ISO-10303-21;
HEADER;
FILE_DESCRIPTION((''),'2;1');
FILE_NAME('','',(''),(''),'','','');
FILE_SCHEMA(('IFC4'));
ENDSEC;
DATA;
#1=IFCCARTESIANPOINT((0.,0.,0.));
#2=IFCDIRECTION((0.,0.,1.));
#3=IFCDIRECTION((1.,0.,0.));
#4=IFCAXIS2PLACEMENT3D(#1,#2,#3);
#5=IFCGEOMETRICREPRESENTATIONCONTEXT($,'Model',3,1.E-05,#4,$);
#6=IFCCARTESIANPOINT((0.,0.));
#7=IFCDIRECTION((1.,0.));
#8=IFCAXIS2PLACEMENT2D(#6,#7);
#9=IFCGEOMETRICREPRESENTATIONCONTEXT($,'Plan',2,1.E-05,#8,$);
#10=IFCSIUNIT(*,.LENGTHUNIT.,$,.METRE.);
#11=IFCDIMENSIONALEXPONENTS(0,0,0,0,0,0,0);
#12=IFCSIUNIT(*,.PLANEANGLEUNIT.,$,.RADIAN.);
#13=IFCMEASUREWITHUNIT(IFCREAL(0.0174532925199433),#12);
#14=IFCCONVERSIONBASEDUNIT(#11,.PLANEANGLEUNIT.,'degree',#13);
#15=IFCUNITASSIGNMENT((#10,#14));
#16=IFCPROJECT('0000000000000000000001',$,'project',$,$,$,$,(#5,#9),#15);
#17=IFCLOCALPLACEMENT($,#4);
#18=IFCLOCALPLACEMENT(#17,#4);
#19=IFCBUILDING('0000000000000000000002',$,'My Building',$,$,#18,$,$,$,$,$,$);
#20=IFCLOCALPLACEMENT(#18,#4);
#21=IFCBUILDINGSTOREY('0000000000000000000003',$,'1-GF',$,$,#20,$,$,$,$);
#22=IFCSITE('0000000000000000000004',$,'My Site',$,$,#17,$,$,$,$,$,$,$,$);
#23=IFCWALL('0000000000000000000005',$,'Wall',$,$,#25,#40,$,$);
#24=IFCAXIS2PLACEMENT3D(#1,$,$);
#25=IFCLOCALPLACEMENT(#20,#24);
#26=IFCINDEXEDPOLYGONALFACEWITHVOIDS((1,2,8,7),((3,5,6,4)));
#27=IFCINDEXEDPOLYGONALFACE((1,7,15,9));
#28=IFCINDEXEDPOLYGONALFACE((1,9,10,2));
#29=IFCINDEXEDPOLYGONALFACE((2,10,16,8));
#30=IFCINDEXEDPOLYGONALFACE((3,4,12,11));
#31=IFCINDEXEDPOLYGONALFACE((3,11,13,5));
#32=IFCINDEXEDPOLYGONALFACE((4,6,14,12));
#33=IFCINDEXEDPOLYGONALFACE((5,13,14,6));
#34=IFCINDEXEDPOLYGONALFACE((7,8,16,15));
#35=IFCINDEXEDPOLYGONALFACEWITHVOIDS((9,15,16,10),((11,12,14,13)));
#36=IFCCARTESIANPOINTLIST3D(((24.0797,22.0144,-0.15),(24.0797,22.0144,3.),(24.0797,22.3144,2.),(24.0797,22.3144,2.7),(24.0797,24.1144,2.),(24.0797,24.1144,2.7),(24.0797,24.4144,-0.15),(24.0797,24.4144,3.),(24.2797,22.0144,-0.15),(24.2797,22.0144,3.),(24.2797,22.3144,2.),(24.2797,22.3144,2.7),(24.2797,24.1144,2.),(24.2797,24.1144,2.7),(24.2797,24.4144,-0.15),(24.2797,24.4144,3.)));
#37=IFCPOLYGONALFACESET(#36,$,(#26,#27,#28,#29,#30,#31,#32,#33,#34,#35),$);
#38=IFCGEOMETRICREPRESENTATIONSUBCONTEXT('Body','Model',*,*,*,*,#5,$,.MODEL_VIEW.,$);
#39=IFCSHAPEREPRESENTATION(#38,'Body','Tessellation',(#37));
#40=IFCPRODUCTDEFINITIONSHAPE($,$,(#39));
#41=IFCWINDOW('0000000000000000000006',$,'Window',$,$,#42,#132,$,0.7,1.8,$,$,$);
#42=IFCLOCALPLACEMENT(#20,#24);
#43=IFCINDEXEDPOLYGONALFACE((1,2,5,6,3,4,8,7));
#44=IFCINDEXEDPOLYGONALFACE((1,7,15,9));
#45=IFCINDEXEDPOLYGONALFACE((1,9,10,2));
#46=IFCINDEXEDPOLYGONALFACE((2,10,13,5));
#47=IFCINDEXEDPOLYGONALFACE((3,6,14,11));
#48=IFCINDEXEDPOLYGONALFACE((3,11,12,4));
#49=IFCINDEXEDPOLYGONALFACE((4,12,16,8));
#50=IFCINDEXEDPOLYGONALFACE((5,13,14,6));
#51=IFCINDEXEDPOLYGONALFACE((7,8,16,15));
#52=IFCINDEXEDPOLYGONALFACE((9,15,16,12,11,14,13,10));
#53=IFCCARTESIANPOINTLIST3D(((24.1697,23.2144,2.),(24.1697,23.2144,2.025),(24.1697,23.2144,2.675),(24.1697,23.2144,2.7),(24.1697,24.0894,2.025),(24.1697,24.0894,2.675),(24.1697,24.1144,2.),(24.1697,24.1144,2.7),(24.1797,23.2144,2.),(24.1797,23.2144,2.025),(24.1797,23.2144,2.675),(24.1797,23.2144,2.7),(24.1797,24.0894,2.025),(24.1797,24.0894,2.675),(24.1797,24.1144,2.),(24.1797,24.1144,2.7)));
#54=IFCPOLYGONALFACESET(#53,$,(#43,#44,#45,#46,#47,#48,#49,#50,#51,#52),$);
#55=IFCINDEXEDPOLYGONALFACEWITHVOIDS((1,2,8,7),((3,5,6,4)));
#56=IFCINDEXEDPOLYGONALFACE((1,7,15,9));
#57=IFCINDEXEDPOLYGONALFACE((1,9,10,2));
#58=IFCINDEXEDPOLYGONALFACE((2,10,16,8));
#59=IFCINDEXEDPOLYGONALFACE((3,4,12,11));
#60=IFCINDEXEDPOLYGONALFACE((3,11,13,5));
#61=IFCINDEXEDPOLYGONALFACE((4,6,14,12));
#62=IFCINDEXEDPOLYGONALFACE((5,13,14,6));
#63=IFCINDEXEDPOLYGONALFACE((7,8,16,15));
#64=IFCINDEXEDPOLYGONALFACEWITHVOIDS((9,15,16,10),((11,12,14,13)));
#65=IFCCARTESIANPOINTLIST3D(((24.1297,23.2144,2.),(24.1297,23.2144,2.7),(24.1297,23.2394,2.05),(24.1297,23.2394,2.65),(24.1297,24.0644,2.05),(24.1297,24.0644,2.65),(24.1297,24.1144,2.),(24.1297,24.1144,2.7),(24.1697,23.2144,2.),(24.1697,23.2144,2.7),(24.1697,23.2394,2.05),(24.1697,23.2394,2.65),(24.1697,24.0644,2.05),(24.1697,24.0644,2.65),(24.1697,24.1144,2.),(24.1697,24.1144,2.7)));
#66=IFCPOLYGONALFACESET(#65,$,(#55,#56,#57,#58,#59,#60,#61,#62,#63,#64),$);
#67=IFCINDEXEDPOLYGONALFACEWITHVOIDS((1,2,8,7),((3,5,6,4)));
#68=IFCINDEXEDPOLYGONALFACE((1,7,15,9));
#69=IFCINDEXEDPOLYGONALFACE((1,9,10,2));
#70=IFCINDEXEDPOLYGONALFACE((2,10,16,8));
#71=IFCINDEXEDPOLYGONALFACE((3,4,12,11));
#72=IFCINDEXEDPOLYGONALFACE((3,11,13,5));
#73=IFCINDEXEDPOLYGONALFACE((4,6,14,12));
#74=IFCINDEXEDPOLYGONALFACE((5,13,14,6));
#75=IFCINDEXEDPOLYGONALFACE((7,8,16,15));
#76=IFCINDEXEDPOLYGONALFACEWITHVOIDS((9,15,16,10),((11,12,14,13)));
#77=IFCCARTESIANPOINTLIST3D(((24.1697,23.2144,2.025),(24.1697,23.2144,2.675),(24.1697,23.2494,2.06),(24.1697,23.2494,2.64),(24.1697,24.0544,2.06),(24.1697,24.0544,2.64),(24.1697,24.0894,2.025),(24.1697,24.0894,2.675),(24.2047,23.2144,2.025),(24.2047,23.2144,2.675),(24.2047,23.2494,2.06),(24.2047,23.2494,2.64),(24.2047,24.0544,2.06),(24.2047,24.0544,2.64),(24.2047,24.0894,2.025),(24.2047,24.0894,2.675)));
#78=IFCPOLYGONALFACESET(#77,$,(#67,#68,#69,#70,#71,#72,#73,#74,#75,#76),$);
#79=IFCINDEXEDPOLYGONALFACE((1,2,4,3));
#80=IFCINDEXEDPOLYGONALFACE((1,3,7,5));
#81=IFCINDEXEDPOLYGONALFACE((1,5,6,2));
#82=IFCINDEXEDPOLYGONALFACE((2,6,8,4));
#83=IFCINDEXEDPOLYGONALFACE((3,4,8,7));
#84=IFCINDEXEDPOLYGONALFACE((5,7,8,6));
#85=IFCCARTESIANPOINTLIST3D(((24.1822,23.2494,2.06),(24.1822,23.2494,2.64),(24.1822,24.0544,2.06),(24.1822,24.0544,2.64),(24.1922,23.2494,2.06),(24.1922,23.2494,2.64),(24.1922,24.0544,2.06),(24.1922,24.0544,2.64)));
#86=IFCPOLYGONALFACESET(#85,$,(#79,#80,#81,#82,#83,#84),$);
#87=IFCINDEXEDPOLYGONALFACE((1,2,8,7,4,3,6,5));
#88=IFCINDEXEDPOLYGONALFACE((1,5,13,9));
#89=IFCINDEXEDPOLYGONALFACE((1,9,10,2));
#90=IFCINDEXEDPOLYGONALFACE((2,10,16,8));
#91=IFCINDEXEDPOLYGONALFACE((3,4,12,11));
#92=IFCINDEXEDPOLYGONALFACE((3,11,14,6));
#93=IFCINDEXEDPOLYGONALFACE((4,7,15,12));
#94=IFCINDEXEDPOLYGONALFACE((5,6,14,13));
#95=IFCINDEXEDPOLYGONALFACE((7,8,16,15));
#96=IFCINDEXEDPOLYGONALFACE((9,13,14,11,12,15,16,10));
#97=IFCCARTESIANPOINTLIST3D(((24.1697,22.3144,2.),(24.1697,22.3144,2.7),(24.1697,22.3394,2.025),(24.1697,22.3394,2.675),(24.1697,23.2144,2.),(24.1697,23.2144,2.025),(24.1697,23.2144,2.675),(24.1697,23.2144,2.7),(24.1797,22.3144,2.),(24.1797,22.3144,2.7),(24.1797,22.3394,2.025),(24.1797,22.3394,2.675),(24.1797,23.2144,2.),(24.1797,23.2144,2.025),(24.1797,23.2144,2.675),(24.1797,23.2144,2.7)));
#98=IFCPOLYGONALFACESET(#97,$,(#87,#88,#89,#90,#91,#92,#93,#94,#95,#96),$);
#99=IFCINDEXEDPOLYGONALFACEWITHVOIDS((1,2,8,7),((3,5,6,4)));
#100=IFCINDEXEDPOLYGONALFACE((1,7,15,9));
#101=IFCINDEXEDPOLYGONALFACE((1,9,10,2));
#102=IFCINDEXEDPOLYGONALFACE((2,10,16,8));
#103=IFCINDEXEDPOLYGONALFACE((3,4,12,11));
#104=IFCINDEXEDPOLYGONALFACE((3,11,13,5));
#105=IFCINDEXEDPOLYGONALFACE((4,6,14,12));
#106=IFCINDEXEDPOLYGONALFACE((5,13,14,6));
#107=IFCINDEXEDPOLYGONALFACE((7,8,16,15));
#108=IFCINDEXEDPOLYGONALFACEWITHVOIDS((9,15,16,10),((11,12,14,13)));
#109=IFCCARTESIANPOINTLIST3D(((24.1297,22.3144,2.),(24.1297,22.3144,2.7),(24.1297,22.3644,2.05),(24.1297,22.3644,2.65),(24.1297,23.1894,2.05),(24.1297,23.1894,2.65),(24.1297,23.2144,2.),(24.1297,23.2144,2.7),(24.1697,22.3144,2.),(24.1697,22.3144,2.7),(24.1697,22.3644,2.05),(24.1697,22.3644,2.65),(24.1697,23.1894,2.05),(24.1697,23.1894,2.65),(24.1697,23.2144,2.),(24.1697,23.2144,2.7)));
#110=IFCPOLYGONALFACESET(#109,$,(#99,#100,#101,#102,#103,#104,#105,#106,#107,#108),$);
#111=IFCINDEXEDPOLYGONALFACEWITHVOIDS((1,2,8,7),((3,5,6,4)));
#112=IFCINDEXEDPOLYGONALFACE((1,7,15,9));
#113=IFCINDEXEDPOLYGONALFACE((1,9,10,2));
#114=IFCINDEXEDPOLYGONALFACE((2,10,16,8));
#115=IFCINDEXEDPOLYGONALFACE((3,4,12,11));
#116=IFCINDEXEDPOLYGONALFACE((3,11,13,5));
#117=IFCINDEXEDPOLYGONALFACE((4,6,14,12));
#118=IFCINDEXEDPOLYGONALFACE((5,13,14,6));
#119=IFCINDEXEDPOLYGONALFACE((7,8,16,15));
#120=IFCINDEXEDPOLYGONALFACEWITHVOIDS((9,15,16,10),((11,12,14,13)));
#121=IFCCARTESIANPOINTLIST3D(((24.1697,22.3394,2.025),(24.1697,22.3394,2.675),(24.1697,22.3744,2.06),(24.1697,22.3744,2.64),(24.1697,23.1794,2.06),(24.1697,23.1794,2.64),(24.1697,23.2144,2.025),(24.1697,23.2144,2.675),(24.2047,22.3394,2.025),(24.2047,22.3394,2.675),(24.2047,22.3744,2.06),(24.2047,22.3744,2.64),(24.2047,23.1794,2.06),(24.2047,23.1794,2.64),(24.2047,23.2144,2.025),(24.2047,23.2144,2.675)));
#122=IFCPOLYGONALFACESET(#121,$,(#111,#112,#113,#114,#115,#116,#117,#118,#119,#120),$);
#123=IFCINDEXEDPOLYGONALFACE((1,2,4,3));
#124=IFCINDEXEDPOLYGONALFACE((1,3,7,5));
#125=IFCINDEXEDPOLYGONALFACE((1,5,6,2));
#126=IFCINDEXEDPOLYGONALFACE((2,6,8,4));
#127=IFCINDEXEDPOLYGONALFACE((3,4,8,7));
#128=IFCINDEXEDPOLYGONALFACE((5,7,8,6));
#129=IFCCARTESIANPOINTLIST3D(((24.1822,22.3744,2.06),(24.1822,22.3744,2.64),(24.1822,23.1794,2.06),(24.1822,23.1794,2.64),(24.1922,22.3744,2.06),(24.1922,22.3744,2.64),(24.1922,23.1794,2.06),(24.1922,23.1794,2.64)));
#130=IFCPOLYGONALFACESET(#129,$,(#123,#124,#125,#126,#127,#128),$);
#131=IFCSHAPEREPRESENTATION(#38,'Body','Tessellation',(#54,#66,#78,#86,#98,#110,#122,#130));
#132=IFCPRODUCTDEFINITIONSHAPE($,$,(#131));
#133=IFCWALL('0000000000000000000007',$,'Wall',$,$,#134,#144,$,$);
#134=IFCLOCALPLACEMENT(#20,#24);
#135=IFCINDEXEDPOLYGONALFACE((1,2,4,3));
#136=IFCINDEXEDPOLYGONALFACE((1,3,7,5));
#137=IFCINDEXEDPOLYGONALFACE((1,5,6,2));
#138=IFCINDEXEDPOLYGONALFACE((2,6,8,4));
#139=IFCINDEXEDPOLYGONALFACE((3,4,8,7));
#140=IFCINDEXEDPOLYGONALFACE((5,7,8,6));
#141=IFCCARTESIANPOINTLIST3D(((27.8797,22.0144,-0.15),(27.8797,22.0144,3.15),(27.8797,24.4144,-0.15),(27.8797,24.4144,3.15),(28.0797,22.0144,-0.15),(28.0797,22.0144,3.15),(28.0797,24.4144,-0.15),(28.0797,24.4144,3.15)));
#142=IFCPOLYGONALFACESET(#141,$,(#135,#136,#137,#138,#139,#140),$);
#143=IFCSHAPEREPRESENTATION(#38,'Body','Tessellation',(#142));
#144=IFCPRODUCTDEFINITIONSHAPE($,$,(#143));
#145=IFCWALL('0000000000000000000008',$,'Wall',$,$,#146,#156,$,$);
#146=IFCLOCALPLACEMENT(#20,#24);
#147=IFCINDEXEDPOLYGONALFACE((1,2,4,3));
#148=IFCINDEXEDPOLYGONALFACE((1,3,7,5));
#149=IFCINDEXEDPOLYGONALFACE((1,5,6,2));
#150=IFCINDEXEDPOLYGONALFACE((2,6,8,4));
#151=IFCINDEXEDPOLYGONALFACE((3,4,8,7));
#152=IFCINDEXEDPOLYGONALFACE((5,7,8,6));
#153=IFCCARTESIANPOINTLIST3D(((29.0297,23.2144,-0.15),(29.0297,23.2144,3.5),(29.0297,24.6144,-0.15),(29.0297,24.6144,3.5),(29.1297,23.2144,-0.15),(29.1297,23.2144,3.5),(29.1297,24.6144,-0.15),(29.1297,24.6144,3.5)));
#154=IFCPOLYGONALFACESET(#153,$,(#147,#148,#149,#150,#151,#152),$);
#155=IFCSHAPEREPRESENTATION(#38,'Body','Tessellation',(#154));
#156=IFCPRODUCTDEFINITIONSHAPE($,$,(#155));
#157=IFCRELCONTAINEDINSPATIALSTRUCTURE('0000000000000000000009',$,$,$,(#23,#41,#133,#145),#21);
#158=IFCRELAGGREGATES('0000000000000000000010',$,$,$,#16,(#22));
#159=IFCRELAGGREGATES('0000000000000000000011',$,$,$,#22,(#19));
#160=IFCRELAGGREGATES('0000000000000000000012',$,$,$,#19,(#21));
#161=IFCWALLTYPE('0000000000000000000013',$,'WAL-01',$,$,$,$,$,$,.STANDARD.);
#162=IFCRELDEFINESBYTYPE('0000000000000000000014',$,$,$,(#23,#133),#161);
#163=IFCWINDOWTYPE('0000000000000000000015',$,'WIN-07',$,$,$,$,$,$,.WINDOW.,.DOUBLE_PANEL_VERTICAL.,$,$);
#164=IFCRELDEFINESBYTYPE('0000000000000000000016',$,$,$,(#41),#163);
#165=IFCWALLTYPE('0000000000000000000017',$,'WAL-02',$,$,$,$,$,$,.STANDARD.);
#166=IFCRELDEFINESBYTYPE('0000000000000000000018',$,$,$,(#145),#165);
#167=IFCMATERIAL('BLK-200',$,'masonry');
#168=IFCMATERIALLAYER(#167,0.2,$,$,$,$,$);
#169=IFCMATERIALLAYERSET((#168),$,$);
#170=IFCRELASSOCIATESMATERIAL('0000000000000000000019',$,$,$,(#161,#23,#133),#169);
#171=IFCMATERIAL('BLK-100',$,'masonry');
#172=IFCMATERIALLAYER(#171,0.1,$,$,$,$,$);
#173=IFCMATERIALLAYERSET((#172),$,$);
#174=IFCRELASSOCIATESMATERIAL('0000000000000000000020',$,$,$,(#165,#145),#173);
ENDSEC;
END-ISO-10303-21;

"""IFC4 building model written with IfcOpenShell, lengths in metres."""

from ifc_helpers import new_model, entity, si_unit, converted_unit, frame, origin_with_axes, origin_2d_with_axis, place, context, subcontext, project, spatial, line, indexed_curve, outline, extrude, shape, source, transform, mapped, material, layer, layer_set, layer_usage, type_object, type_shapes, element, fill, save


model = new_model("IFC4")

# Units and contexts
model_context = context("Model", 3, precision=1e-05, world=origin_with_axes())
plan_context = context("Plan", 2, precision=1e-05, world=origin_2d_with_axis())
body_context_1 = subcontext(model_context, "Body", "Model", "MODEL_VIEW")
body_context_2 = subcontext(plan_context, "Body", "Plan", "PLAN_VIEW")
ifc_project = project(units=[si_unit("LENGTHUNIT", "METRE"), converted_unit("PLANEANGLEUNIT", "degree", entity("IfcReal", 0.0174532925199433), si_unit("PLANEANGLEUNIT", "RADIAN"), dimensions=[0, 0, 0, 0, 0, 0, 0])], contexts=[model_context, plan_context])

# Site, building, storey
site_placement = place(None, origin_with_axes())
site = spatial("IfcSite", under=ifc_project, at=site_placement, Name="My Site")
building_placement = place(site_placement, origin_with_axes())
building = spatial("IfcBuilding", under=site, at=building_placement, Name="My Building")
storey_placement = place(building_placement, origin_with_axes())
storey = spatial("IfcBuildingStorey", under=building, at=storey_placement, Name="1-GF")

# Wall, opening, window
ifc_material_1 = material(Name="BLK-200", Category="masonry")
ifc_layer_1 = layer(ifc_material_1, 0.2)
ifc_layer_set_1 = layer_set([ifc_layer_1])
ifc_layer_usage_1 = layer_usage(ifc_layer_set_1, "AXIS2", "POSITIVE", 0.0)
wall_type_1 = type_object("IfcWallType", Name="WAL-01", PredefinedType="STANDARD", material=ifc_layer_set_1)
wall_1_placement = place(storey_placement, frame((24.0797, 24.4144, -0.15), z_axis=(0.0, 0.0, 1.0), x_axis=(-0.000001, -1.0, 0.0)))
wall_1 = element("IfcWall", 1, at=wall_1_placement, inside=storey, type_object=wall_type_1, material=ifc_layer_usage_1, Name="Wall", context=body_context_1, shape_type="SweptSolid", body=[
    extrude(outline(indexed_curve([(0.0, 0.0), (0.0, 0.2), (2.4, 0.2), (2.4, 0.0), (0.0, 0.0)], self_intersect=False)), origin_with_axes(), (0.0, 0.0, 1.0), 3.15),
])
shared_shape_1 = source(origin_with_axes(), body_context_1, "Body", "SweptSolid", [
    extrude(outline(indexed_curve([(0.0, 0.0), (1.8, 0.0), (1.8, 0.7), (0.0, 0.7)], segments=[line(1, 2, 3, 4, 1)])), frame((0.0, -0.1, 0.0), z_axis=(0.0, -1.0, 0.0), x_axis=(1.0, 0.0, 0.0)), (0.0, 0.0, -1.0), 0.4),
])
opening_1_placement = place(wall_1_placement, frame((0.3, 0.0, 2.15), z_axis=(0.0, 0.0, 1.0), x_axis=(1.0, 0.0, 0.0)))
opening_1 = element("IfcOpeningElement", 2, at=opening_1_placement, cuts=wall_1, PredefinedType="OPENING", context=body_context_1, shape_type="MappedRepresentation", body=[
    mapped(shared_shape_1, transform((0.0, 0.0, 0.0), x_axis=(1.0, 0.0, 0.0), y_axis=(0.0, 1.0, 0.0), z_axis=(0.0, 0.0, 1.0), scale=1.0)),
])
window_type = type_object("IfcWindowType", Name="WIN-07", PartitioningType="DOUBLE_PANEL_VERTICAL", PredefinedType="WINDOW")
shared_shape_2 = source(origin_with_axes(), body_context_1, "Body", "SweptSolid", [
    extrude(outline(indexed_curve([(0.9, 0.0), (0.0, 0.0), (0.0, 0.7), (0.9, 0.7), (0.9, 0.675), (0.025, 0.675), (0.025, 0.025), (0.9, 0.025)], segments=[line(1, 2, 3, 4, 5, 6, 7, 8, 1)])), frame((0.0, 0.09, 0.0), z_axis=(0.0, -1.0, 0.0), x_axis=(1.0, 0.0, 0.0)), (0.0, 0.0, -1.0), 0.01),
    extrude(outline(indexed_curve([(0.0, 0.0), (0.9, 0.0), (0.9, 0.7), (0.0, 0.7)], segments=[line(1, 2, 3, 4, 1)]), holes=[indexed_curve([(0.05, 0.05), (0.875, 0.05), (0.875, 0.65), (0.05, 0.65)], segments=[line(1, 2, 3, 4, 1)])]), frame((0.0, 0.05, 0.0), z_axis=(0.0, -1.0, 0.0), x_axis=(1.0, 0.0, 0.0)), (0.0, 0.0, -1.0), 0.04),
    extrude(outline(indexed_curve([(0.0, 0.0), (0.875, 0.0), (0.875, 0.65), (0.0, 0.65)], segments=[line(1, 2, 3, 4, 1)]), holes=[indexed_curve([(0.035, 0.035), (0.84, 0.035), (0.84, 0.615), (0.035, 0.615)], segments=[line(1, 2, 3, 4, 1)])]), frame((0.025, 0.09, 0.025), z_axis=(0.0, -1.0, 0.0), x_axis=(1.0, 0.0, 0.0)), (0.0, 0.0, -1.0), 0.035),
    extrude(outline(indexed_curve([(0.035, 0.035), (0.84, 0.035), (0.84, 0.615), (0.035, 0.615)], segments=[line(1, 2, 3, 4, 1)])), frame((0.025, 0.1025, 0.025), z_axis=(0.0, -1.0, 0.0), x_axis=(1.0, 0.0, 0.0)), (0.0, 0.0, -1.0), 0.01),
    extrude(outline(indexed_curve([(0.0, 0.7), (0.9, 0.7), (0.9, 0.0), (0.0, 0.0), (0.0, 0.025), (0.875, 0.025), (0.875, 0.675), (0.0, 0.675)], segments=[line(1, 2, 3, 4, 5, 6, 7, 8, 1)])), frame((0.9, 0.09, 0.0), z_axis=(0.0, -1.0, 0.0), x_axis=(1.0, 0.0, 0.0)), (0.0, 0.0, -1.0), 0.01),
    extrude(outline(indexed_curve([(0.0, 0.0), (0.9, 0.0), (0.9, 0.7), (0.0, 0.7)], segments=[line(1, 2, 3, 4, 1)]), holes=[indexed_curve([(0.025, 0.05), (0.85, 0.05), (0.85, 0.65), (0.025, 0.65)], segments=[line(1, 2, 3, 4, 1)])]), frame((0.9, 0.05, 0.0), z_axis=(0.0, -1.0, 0.0), x_axis=(1.0, 0.0, 0.0)), (0.0, 0.0, -1.0), 0.04),
    extrude(outline(indexed_curve([(0.0, 0.0), (0.875, 0.0), (0.875, 0.65), (0.0, 0.65)], segments=[line(1, 2, 3, 4, 1)]), holes=[indexed_curve([(0.035, 0.035), (0.84, 0.035), (0.84, 0.615), (0.035, 0.615)], segments=[line(1, 2, 3, 4, 1)])]), frame((0.9, 0.09, 0.025), z_axis=(0.0, -1.0, 0.0), x_axis=(1.0, 0.0, 0.0)), (0.0, 0.0, -1.0), 0.035),
    extrude(outline(indexed_curve([(0.035, 0.035), (0.84, 0.035), (0.84, 0.615), (0.035, 0.615)], segments=[line(1, 2, 3, 4, 1)])), frame((0.9, 0.1025, 0.025), z_axis=(0.0, -1.0, 0.0), x_axis=(1.0, 0.0, 0.0)), (0.0, 0.0, -1.0), 0.01),
])
shared_shape_3 = source(origin_with_axes(), body_context_2, "Body", "Curve2D", [
    entity("IfcIndexedPolyCurve", entity("IfcCartesianPointList2D", [[0.05, 0.05], [0.875, 0.05]])),
    entity("IfcIndexedPolyCurve", entity("IfcCartesianPointList2D", [[0.0, 0.1], [0.025, 0.1], [0.025, 0.09], [0.05, 0.09], [0.05, 0.05], [0.0, 0.05]]), [entity("IfcLineIndex", [1, 2, 3, 4, 5, 6, 1])]),
    entity("IfcIndexedPolyCurve", entity("IfcCartesianPointList2D", [[0.9, 0.1], [0.9, 0.1], [0.9, 0.09], [0.875, 0.09], [0.875, 0.05], [0.9, 0.05]])),
    entity("IfcIndexedPolyCurve", entity("IfcCartesianPointList2D", [[0.025, 0.09], [0.06, 0.09], [0.06, 0.125], [0.025, 0.125]]), [entity("IfcLineIndex", [1, 2, 3, 4, 1])]),
    entity("IfcIndexedPolyCurve", entity("IfcCartesianPointList2D", [[0.9, 0.09], [0.865, 0.09], [0.865, 0.125], [0.9, 0.125]]), [entity("IfcLineIndex", [1, 2, 3, 4, 1])]),
    entity("IfcIndexedPolyCurve", entity("IfcCartesianPointList2D", [[0.06, 0.09], [0.865, 0.09]])),
    entity("IfcIndexedPolyCurve", entity("IfcCartesianPointList2D", [[0.06, 0.125], [0.865, 0.125]])),
    entity("IfcIndexedPolyCurve", entity("IfcCartesianPointList2D", [[0.06, 0.1075], [0.865, 0.1075]])),
    entity("IfcIndexedPolyCurve", entity("IfcCartesianPointList2D", [[0.925, 0.05], [1.75, 0.05]])),
    entity("IfcIndexedPolyCurve", entity("IfcCartesianPointList2D", [[0.9, 0.1], [0.9, 0.1], [0.9, 0.09], [0.925, 0.09], [0.925, 0.05], [0.9, 0.05]])),
    entity("IfcIndexedPolyCurve", entity("IfcCartesianPointList2D", [[1.8, 0.1], [1.775, 0.1], [1.775, 0.09], [1.75, 0.09], [1.75, 0.05], [1.8, 0.05]]), [entity("IfcLineIndex", [1, 2, 3, 4, 5, 6, 1])]),
    entity("IfcIndexedPolyCurve", entity("IfcCartesianPointList2D", [[0.9, 0.09], [0.935, 0.09], [0.935, 0.125], [0.9, 0.125]]), [entity("IfcLineIndex", [1, 2, 3, 4, 1])]),
    entity("IfcIndexedPolyCurve", entity("IfcCartesianPointList2D", [[1.775, 0.09], [1.74, 0.09], [1.74, 0.125], [1.775, 0.125]]), [entity("IfcLineIndex", [1, 2, 3, 4, 1])]),
    entity("IfcIndexedPolyCurve", entity("IfcCartesianPointList2D", [[0.935, 0.09], [1.74, 0.09]])),
    entity("IfcIndexedPolyCurve", entity("IfcCartesianPointList2D", [[0.935, 0.125], [1.74, 0.125]])),
    entity("IfcIndexedPolyCurve", entity("IfcCartesianPointList2D", [[0.935, 0.1075], [1.74, 0.1075]])),
])
type_shapes(window_type, [shared_shape_2, shared_shape_3])
window_placement = place(opening_1_placement, frame((0.0, 0.0, 0.0), z_axis=(0.0, 0.0, 1.0), x_axis=(1.0, 0.0, 0.0)))
window = element("IfcWindow", 3, at=window_placement, inside=storey, type_object=window_type, Name="Window", OverallHeight=0.7, OverallWidth=1.8, shapes=[
    shape(body_context_1, "Body", "MappedRepresentation", [mapped(shared_shape_2, transform((0.0, 0.0, 0.0), x_axis=(1.0, 0.0, 0.0), y_axis=(0.0, 1.0, 0.0), z_axis=(0.0, 0.0, 1.0), scale=1.0))]),
    shape(body_context_2, "Body", "MappedRepresentation", [mapped(shared_shape_3, transform((0.0, 0.0, 0.0), x_axis=(1.0, 0.0, 0.0), y_axis=(0.0, 1.0, 0.0), z_axis=(0.0, 0.0, 1.0), scale=1.0))]),
])
fill(opening_1, window)

# Walls
ifc_layer_usage_2 = layer_usage(ifc_layer_set_1, "AXIS2", "POSITIVE", 0.0)
wall_2_placement = place(storey_placement, frame((27.8797, 24.4144, -0.15), z_axis=(0.0, 0.0, 1.0), x_axis=(-0.000001, -1.0, 0.0)))
element("IfcWall", 4, at=wall_2_placement, inside=storey, type_object=wall_type_1, material=ifc_layer_usage_2, Name="Wall", context=body_context_1, shape_type="SweptSolid", body=[
    extrude(outline(indexed_curve([(0.0, 0.0), (0.0, 0.2), (2.4, 0.2), (2.4, 0.0), (0.0, 0.0)], self_intersect=False)), origin_with_axes(), (0.0, 0.0, 1.0), 3.3),
])
ifc_material_2 = material(Name="BLK-100", Category="masonry")
ifc_layer_2 = layer(ifc_material_2, 0.1)
ifc_layer_set_2 = layer_set([ifc_layer_2])
ifc_layer_usage_3 = layer_usage(ifc_layer_set_2, "AXIS2", "POSITIVE", 0.0)
wall_type_2 = type_object("IfcWallType", Name="WAL-02", PredefinedType="STANDARD", material=ifc_layer_set_2)
wall_3_placement = place(storey_placement, frame((29.1297, 23.2144, -0.15), z_axis=(0.0, 0.0, 1.0), x_axis=(0.0, 1.0, 0.0)))
element("IfcWall", 5, at=wall_3_placement, inside=storey, type_object=wall_type_2, material=ifc_layer_usage_3, Name="Wall", context=body_context_1, shape_type="SweptSolid", body=[
    extrude(outline(indexed_curve([(0.0, 0.0), (0.0, 0.1), (1.4, 0.1), (1.4, 0.0), (0.0, 0.0)], self_intersect=False)), origin_with_axes(), (0.0, 0.0, 1.0), 3.65),
])

save(model, "model.ifc")
